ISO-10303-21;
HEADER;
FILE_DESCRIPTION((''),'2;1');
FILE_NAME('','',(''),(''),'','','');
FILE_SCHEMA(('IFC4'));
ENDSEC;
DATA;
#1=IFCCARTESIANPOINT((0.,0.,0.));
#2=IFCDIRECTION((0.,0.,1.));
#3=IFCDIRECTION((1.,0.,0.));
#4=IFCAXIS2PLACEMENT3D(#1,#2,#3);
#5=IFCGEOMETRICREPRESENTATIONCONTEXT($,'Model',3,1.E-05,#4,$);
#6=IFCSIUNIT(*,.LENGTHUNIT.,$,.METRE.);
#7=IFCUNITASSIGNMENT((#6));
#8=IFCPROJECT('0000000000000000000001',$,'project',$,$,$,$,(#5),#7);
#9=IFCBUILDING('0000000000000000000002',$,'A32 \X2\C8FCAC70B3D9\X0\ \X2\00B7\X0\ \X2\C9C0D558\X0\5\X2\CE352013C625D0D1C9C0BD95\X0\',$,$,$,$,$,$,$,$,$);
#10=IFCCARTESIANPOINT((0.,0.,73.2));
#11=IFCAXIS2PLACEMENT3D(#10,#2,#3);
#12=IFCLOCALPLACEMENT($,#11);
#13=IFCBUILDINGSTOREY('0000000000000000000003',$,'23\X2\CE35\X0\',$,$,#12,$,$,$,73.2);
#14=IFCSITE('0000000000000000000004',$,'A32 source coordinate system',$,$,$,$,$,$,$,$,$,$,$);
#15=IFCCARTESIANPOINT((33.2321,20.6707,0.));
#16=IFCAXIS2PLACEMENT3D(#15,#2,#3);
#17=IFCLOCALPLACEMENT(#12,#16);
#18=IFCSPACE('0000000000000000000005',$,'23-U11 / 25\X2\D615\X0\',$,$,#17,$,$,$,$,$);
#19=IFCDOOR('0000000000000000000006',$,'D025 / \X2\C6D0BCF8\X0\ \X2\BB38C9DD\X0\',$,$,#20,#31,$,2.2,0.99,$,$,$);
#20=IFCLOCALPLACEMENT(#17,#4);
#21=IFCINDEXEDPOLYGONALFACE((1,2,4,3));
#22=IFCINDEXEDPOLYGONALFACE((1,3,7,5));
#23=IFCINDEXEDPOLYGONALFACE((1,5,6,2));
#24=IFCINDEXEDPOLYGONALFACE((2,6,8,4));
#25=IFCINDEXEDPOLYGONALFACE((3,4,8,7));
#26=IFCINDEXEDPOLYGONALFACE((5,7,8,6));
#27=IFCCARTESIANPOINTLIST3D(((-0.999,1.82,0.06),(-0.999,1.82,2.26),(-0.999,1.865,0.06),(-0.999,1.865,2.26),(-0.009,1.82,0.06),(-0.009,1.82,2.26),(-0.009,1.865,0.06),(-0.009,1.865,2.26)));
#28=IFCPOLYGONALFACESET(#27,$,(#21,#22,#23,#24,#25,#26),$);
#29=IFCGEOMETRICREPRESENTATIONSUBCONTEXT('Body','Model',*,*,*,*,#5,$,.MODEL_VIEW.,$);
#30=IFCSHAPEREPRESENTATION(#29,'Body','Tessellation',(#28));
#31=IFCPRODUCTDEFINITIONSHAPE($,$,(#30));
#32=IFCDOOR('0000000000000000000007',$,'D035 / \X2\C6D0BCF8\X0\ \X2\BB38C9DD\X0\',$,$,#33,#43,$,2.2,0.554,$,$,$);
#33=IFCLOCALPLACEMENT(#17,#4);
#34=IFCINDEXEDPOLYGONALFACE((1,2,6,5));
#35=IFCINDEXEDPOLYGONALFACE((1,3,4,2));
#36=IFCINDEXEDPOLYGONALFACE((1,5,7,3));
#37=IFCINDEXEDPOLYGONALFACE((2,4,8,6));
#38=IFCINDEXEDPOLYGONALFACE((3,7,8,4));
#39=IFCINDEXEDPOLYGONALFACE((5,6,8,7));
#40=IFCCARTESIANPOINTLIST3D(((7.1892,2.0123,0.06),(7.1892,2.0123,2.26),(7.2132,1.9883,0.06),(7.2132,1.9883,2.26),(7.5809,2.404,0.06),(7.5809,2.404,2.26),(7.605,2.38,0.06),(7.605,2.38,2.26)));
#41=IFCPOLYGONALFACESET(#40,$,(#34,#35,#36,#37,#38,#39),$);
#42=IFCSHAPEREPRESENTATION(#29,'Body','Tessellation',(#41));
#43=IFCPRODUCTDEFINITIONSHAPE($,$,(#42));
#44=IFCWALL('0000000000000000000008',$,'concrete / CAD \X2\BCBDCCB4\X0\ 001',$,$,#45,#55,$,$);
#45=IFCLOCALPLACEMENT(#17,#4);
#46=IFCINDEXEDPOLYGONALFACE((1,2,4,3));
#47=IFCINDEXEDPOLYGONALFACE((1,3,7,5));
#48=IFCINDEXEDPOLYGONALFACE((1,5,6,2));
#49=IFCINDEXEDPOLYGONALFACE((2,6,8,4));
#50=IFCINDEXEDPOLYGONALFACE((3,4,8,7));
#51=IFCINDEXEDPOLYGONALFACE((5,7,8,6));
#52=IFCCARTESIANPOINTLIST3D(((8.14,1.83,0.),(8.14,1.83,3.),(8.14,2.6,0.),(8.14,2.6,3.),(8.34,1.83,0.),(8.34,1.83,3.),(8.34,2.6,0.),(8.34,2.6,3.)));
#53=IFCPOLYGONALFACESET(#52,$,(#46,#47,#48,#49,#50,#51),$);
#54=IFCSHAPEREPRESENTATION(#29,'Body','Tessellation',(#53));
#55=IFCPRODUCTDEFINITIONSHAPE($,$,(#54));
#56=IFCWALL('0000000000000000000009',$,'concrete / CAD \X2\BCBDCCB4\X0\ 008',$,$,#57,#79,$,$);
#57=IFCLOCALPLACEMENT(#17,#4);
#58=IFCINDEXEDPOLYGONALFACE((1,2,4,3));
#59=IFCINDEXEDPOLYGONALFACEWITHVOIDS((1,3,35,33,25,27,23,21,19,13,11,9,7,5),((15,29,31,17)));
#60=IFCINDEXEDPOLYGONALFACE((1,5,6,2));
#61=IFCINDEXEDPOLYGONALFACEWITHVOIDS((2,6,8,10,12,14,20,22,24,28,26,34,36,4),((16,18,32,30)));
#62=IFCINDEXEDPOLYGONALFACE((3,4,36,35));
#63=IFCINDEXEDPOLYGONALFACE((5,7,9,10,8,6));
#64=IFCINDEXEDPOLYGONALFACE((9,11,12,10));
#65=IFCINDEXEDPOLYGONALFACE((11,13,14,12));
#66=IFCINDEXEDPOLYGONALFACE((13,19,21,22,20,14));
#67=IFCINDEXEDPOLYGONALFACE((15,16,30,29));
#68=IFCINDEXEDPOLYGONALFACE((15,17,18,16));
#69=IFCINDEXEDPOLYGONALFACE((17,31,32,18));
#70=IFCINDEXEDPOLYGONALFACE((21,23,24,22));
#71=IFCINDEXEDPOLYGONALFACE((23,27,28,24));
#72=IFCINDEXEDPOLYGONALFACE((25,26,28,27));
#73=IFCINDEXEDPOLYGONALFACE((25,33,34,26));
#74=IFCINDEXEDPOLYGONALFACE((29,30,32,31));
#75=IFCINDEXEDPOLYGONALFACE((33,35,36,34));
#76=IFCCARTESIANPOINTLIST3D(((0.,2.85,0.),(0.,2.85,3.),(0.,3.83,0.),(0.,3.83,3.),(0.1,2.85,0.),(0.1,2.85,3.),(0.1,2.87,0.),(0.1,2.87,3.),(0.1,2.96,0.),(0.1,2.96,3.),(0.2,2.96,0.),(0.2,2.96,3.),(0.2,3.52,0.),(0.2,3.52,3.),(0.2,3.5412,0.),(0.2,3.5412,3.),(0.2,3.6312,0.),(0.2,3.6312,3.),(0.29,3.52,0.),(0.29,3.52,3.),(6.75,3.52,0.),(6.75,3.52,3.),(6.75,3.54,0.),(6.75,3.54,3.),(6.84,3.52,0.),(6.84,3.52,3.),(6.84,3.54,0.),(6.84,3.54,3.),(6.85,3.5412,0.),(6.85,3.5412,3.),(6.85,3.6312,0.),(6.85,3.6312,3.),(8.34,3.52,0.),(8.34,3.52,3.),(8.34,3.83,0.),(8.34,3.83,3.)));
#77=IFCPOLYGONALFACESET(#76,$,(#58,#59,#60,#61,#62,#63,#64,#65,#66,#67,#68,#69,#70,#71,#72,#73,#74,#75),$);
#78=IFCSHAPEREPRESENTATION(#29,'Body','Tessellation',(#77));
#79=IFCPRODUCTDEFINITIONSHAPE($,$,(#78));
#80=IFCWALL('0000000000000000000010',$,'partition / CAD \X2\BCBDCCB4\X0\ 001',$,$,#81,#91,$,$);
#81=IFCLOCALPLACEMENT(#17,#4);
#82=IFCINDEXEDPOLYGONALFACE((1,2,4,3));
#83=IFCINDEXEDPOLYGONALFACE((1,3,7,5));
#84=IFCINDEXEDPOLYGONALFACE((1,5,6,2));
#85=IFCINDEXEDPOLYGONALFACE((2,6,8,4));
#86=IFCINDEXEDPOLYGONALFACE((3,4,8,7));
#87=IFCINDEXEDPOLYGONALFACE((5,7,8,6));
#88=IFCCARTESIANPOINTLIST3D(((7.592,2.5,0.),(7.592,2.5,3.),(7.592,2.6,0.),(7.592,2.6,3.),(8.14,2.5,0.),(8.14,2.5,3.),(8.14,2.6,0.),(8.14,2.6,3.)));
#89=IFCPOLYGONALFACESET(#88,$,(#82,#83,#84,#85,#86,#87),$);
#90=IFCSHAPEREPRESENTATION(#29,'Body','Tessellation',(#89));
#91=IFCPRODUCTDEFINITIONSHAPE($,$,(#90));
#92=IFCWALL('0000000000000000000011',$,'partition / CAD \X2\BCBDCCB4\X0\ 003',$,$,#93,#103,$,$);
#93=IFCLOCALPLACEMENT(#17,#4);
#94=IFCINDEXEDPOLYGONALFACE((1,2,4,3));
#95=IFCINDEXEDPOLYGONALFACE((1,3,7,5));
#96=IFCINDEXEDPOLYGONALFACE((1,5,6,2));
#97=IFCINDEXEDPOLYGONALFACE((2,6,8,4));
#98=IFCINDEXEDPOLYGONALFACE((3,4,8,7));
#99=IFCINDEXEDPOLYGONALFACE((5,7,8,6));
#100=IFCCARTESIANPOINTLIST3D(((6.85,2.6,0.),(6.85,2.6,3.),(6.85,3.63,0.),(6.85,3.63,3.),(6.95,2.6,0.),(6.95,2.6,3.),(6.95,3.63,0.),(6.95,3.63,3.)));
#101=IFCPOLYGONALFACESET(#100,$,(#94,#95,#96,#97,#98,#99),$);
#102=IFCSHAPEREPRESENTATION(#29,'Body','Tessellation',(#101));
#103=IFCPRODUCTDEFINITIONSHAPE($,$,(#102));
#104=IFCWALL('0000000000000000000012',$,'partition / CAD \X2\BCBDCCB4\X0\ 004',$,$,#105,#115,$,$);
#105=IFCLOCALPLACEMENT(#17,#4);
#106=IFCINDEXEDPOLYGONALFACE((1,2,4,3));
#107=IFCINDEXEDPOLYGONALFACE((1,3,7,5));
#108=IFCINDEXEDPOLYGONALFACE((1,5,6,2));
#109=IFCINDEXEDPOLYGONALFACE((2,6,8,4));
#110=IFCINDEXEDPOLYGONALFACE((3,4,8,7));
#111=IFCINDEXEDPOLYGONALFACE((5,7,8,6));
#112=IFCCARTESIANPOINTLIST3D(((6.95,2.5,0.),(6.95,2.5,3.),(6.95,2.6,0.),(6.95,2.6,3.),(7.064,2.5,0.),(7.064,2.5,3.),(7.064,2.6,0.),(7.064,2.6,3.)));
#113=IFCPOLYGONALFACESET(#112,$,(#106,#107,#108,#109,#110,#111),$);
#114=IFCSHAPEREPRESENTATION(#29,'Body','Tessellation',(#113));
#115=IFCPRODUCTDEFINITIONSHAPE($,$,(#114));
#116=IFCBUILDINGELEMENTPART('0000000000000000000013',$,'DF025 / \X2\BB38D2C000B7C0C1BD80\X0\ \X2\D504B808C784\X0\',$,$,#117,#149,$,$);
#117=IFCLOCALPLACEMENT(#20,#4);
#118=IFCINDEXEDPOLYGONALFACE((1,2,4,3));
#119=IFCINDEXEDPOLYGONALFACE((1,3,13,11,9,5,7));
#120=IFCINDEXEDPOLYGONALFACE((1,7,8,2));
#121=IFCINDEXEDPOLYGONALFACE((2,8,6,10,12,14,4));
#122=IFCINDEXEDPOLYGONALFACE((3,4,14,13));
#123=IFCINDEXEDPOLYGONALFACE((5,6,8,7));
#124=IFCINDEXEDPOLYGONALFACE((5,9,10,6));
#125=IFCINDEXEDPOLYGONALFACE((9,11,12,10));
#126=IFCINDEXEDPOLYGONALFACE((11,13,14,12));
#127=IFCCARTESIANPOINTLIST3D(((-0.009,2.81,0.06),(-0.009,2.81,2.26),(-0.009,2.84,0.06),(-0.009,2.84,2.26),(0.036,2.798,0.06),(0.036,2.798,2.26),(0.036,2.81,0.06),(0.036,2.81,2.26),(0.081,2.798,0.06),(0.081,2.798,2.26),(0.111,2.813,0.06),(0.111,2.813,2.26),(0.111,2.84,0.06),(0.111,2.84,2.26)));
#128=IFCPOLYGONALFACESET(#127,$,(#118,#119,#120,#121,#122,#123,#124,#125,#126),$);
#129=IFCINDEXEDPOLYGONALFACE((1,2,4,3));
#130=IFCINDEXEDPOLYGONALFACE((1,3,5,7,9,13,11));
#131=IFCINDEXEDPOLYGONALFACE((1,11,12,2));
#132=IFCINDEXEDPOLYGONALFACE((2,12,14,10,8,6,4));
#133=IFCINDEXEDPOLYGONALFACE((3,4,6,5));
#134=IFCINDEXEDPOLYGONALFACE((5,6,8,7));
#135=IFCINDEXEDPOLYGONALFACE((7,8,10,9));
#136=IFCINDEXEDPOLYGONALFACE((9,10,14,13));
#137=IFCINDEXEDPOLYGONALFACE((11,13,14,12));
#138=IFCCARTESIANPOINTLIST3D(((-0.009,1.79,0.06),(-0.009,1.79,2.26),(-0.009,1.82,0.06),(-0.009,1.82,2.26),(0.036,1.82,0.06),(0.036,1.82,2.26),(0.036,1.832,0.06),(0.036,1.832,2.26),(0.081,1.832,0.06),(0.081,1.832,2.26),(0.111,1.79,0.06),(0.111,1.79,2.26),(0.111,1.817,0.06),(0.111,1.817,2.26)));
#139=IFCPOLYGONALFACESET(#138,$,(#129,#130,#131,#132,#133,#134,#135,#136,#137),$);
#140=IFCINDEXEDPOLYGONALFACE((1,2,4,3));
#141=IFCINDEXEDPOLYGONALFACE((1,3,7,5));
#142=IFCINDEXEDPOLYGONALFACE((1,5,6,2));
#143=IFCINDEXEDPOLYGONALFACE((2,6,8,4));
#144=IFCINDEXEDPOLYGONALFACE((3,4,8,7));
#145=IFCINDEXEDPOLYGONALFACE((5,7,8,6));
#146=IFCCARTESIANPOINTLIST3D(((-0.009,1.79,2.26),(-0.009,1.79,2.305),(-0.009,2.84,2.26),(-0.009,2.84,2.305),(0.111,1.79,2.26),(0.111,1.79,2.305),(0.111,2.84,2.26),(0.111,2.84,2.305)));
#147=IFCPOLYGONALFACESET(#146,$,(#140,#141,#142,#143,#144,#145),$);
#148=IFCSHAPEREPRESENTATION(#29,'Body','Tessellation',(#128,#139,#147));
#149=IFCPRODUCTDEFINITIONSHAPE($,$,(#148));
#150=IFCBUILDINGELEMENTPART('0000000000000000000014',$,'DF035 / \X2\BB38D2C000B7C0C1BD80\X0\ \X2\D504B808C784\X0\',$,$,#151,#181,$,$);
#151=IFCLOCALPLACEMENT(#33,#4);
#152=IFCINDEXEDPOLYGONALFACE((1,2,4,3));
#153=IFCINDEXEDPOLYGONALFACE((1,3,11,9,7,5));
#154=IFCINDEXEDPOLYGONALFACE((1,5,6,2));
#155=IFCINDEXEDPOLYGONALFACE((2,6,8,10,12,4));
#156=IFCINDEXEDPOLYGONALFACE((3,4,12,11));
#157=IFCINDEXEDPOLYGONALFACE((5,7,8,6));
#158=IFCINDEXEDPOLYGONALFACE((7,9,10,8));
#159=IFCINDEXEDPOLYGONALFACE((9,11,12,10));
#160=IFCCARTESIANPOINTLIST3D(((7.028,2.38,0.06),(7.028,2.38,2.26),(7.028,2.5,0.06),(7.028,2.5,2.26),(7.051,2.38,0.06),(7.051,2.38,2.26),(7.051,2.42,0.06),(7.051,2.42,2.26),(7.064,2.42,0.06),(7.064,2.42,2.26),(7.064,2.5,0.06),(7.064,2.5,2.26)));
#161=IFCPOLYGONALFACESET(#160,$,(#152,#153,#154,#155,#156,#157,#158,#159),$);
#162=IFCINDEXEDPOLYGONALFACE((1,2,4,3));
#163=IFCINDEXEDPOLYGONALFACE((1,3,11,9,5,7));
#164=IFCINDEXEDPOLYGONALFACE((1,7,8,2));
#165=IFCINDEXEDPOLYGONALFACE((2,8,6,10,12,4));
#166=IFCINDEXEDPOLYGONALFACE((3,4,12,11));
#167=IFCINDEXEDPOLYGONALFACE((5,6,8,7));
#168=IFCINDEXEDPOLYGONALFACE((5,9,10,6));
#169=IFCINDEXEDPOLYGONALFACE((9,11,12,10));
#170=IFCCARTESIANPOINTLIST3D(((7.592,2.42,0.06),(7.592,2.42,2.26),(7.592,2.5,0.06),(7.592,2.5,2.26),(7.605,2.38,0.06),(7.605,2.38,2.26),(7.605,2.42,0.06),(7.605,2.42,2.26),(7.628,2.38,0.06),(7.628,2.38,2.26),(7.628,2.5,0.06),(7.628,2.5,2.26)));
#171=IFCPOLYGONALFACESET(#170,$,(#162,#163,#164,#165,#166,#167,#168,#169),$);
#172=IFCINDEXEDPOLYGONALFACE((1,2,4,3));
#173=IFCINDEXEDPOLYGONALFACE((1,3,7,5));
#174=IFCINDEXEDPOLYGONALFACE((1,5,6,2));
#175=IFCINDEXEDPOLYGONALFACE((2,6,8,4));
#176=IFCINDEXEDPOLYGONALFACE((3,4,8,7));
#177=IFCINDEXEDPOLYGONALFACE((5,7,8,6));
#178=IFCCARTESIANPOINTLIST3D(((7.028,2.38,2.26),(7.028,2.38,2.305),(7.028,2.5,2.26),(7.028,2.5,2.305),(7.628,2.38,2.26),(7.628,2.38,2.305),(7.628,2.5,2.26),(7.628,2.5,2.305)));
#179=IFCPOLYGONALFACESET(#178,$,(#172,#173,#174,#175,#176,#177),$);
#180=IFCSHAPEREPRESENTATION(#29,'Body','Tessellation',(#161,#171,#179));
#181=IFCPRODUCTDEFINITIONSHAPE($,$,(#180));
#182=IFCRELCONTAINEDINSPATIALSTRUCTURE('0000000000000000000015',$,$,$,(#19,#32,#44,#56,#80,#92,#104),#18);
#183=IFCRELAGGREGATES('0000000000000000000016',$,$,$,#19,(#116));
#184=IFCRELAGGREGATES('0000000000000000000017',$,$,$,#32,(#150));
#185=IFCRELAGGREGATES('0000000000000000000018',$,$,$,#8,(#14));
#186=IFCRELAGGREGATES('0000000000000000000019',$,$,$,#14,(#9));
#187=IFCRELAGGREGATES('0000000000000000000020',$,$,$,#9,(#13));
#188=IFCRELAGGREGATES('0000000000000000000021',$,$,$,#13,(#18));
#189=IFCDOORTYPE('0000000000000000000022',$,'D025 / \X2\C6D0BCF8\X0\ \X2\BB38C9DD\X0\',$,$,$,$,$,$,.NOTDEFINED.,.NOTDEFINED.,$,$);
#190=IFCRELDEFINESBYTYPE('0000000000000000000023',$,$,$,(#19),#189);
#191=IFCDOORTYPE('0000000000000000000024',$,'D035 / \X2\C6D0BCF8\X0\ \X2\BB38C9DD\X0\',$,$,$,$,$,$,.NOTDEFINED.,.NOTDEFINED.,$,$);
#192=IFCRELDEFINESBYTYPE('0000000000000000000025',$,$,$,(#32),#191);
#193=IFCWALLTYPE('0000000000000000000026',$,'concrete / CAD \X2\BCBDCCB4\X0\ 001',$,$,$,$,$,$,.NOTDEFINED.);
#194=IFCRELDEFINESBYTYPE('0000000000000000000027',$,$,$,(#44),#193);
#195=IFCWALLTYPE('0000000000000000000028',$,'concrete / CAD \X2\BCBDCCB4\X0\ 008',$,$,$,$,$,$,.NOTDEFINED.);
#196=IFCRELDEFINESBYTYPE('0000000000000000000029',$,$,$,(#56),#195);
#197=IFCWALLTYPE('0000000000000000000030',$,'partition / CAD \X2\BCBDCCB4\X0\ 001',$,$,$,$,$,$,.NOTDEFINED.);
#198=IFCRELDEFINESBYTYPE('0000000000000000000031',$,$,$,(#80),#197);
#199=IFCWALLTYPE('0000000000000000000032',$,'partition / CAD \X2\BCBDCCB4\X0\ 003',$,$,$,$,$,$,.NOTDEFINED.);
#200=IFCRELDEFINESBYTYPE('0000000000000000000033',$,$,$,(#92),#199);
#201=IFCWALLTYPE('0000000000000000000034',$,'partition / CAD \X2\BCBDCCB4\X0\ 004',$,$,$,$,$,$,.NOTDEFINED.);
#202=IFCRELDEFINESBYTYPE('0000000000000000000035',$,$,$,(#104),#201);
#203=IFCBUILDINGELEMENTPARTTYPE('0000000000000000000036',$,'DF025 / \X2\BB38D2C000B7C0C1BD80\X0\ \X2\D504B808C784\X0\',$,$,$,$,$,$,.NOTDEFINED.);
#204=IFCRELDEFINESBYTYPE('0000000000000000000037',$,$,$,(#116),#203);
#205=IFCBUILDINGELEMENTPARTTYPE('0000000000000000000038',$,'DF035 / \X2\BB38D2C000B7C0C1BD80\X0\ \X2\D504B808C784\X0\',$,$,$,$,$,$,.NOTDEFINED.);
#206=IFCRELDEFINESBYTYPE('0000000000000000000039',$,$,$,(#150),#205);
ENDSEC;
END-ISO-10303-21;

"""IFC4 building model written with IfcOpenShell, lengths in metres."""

from ifc_helpers import new_model, si_unit, frame, origin, origin_with_axes, place, context, subcontext, project, spatial, polyline, outline, extrude, source, transform, mapped, type_object, type_shapes, element, aggregate, save


model = new_model("IFC4")

# Units and contexts
model_context = context("Model", 3, precision=1e-05, world=origin_with_axes())
body_context = subcontext(model_context, "Body", "Model", "MODEL_VIEW")
ifc_project = project(units=[si_unit("LENGTHUNIT", "METRE")], contexts=[model_context])

# Site, building, storey, space
storey_placement = place(None, frame((0.0, 0.0, 73.2), z_axis=(0.0, 0.0, 1.0), x_axis=(1.0, 0.0, 0.0)))
space_placement = place(storey_placement, frame((33.2321, 20.6707, 0.0), z_axis=(0.0, 0.0, 1.0), x_axis=(1.0, 0.0, 0.0)))
site = spatial("IfcSite", under=ifc_project, Name="A32 source coordinate system")
building = spatial("IfcBuilding", under=site, Name="A32 주거동 · 지하5층–옥탑지붕")
storey = spatial("IfcBuildingStorey", under=building, at=storey_placement, Name="23층", Elevation=73.2)
space = spatial("IfcSpace", under=storey, at=space_placement, Name="23-U11 / 25형")

# Doors
door_type_1 = type_object("IfcDoorType", Name="D025 / 원본 문짝", OperationType="NOTDEFINED", PredefinedType="NOTDEFINED")
shared_shape_1 = source(origin(), body_context, "Body", "SweptSolid", [
    extrude(outline(polyline([(-0.009, 1.82), (-0.999, 1.82), (-0.999, 1.865), (-0.009, 1.865), (-0.009, 1.82)])), frame((0.0, 0.0, 0.06)), (0.0, 0.0, 1.0), 2.2),
])
type_shapes(door_type_1, [shared_shape_1])
door_1_placement = place(space_placement, origin_with_axes())
door_1 = element("IfcDoor", 1, at=door_1_placement, inside=space, type_object=door_type_1, Name="D025 / 원본 문짝", OverallHeight=2.2, OverallWidth=0.99, context=body_context, shape_type="MappedRepresentation", body=[
    mapped(shared_shape_1, transform((0.0, 0.0, 0.0), scale=1.0)),
])
door_type_2 = type_object("IfcDoorType", Name="D035 / 원본 문짝", OperationType="NOTDEFINED", PredefinedType="NOTDEFINED")
shared_shape_2 = source(origin(), body_context, "Body", "SweptSolid", [
    extrude(outline(polyline([(7.605, 2.38), (7.2132, 1.9883), (7.1892, 2.0123), (7.5809, 2.404), (7.605, 2.38)])), frame((0.0, 0.0, 0.06)), (0.0, 0.0, 1.0), 2.2),
])
type_shapes(door_type_2, [shared_shape_2])
door_2_placement = place(space_placement, origin_with_axes())
door_2 = element("IfcDoor", 2, at=door_2_placement, inside=space, type_object=door_type_2, Name="D035 / 원본 문짝", OverallHeight=2.2, OverallWidth=0.554, context=body_context, shape_type="MappedRepresentation", body=[
    mapped(shared_shape_2, transform((0.0, 0.0, 0.0), scale=1.0)),
])

# Walls
wall_type_1 = type_object("IfcWallType", Name="concrete / CAD 벽체 001", PredefinedType="NOTDEFINED")
shared_shape_3 = source(origin(), body_context, "Body", "SweptSolid", [
    extrude(outline(polyline([(8.34, 1.83), (8.14, 1.83), (8.14, 2.6), (8.34, 2.6), (8.34, 1.83)])), origin(), (0.0, 0.0, 1.0), 3.0),
])
type_shapes(wall_type_1, [shared_shape_3])
wall_1_placement = place(space_placement, origin_with_axes())
element("IfcWall", 3, at=wall_1_placement, inside=space, type_object=wall_type_1, Name="concrete / CAD 벽체 001", context=body_context, shape_type="MappedRepresentation", body=[
    mapped(shared_shape_3, transform((0.0, 0.0, 0.0), scale=1.0)),
])
wall_type_2 = type_object("IfcWallType", Name="concrete / CAD 벽체 008", PredefinedType="NOTDEFINED")
shared_shape_4 = source(origin(), body_context, "Body", "SweptSolid", [
    extrude(outline(polyline([(0.0, 3.83), (8.34, 3.83), (8.34, 3.52), (6.84, 3.52), (6.84, 3.54), (6.75, 3.54), (6.75, 3.52), (0.29, 3.52), (0.2, 3.52), (0.2, 2.96), (0.1, 2.96), (0.1, 2.87), (0.1, 2.85), (0.0, 2.85), (0.0, 3.83)]), holes=[polyline([(6.85, 3.5412), (6.85, 3.6312), (0.2, 3.6312), (0.2, 3.5412), (6.85, 3.5412)])]), origin(), (0.0, 0.0, 1.0), 3.0),
])
type_shapes(wall_type_2, [shared_shape_4])
wall_2_placement = place(space_placement, origin_with_axes())
element("IfcWall", 4, at=wall_2_placement, inside=space, type_object=wall_type_2, Name="concrete / CAD 벽체 008", context=body_context, shape_type="MappedRepresentation", body=[
    mapped(shared_shape_4, transform((0.0, 0.0, 0.0), scale=1.0)),
])
wall_type_3 = type_object("IfcWallType", Name="partition / CAD 벽체 001", PredefinedType="NOTDEFINED")
shared_shape_5 = source(origin(), body_context, "Body", "SweptSolid", [
    extrude(outline(polyline([(8.14, 2.6), (8.14, 2.5), (7.592, 2.5), (7.592, 2.6), (8.14, 2.6)])), origin(), (0.0, 0.0, 1.0), 3.0),
])
type_shapes(wall_type_3, [shared_shape_5])
wall_3_placement = place(space_placement, origin_with_axes())
element("IfcWall", 5, at=wall_3_placement, inside=space, type_object=wall_type_3, Name="partition / CAD 벽체 001", context=body_context, shape_type="MappedRepresentation", body=[
    mapped(shared_shape_5, transform((0.0, 0.0, 0.0), scale=1.0)),
])
wall_type_4 = type_object("IfcWallType", Name="partition / CAD 벽체 003", PredefinedType="NOTDEFINED")
shared_shape_6 = source(origin(), body_context, "Body", "SweptSolid", [
    extrude(outline(polyline([(6.85, 2.6), (6.85, 3.63), (6.95, 3.63), (6.95, 2.6), (6.85, 2.6)])), origin(), (0.0, 0.0, 1.0), 3.0),
])
type_shapes(wall_type_4, [shared_shape_6])
wall_4_placement = place(space_placement, origin_with_axes())
element("IfcWall", 6, at=wall_4_placement, inside=space, type_object=wall_type_4, Name="partition / CAD 벽체 003", context=body_context, shape_type="MappedRepresentation", body=[
    mapped(shared_shape_6, transform((0.0, 0.0, 0.0), scale=1.0)),
])
wall_type_5 = type_object("IfcWallType", Name="partition / CAD 벽체 004", PredefinedType="NOTDEFINED")
shared_shape_7 = source(origin(), body_context, "Body", "SweptSolid", [
    extrude(outline(polyline([(6.95, 2.5), (6.95, 2.6), (7.064, 2.6), (7.064, 2.5), (6.95, 2.5)])), origin(), (0.0, 0.0, 1.0), 3.0),
])
type_shapes(wall_type_5, [shared_shape_7])
wall_5_placement = place(space_placement, origin_with_axes())
element("IfcWall", 7, at=wall_5_placement, inside=space, type_object=wall_type_5, Name="partition / CAD 벽체 004", context=body_context, shape_type="MappedRepresentation", body=[
    mapped(shared_shape_7, transform((0.0, 0.0, 0.0), scale=1.0)),
])

# Building element parts
building_element_part_type_1 = type_object("IfcBuildingElementPartType", Name="DF025 / 문틀·상부 프레임", PredefinedType="NOTDEFINED")
shared_shape_8 = source(origin(), body_context, "Body", "SweptSolid", [
    extrude(outline(polyline([(0.111, 2.84), (0.111, 2.813), (0.081, 2.798), (0.036, 2.798), (0.036, 2.81), (-0.009, 2.81), (-0.009, 2.84), (0.111, 2.84)])), frame((0.0, 0.0, 0.06)), (0.0, 0.0, 1.0), 2.2),
    extrude(outline(polyline([(-0.009, 1.82), (0.036, 1.82), (0.036, 1.832), (0.081, 1.832), (0.111, 1.817), (0.111, 1.79), (-0.009, 1.79), (-0.009, 1.82)])), frame((0.0, 0.0, 0.06)), (0.0, 0.0, 1.0), 2.2),
    extrude(outline(polyline([(-0.009, 1.79), (-0.009, 2.84), (0.111, 2.84), (0.111, 1.79), (-0.009, 1.79)])), frame((0.0, 0.0, 2.26)), (0.0, 0.0, 1.0), 0.045),
])
type_shapes(building_element_part_type_1, [shared_shape_8])
building_element_part_1_placement = place(door_1_placement, origin_with_axes())
building_element_part_1 = element("IfcBuildingElementPart", 8, at=building_element_part_1_placement, type_object=building_element_part_type_1, Name="DF025 / 문틀·상부 프레임", context=body_context, shape_type="MappedRepresentation", body=[
    mapped(shared_shape_8, transform((0.0, 0.0, 0.0), scale=1.0)),
])
aggregate(door_1, [building_element_part_1])
building_element_part_type_2 = type_object("IfcBuildingElementPartType", Name="DF035 / 문틀·상부 프레임", PredefinedType="NOTDEFINED")
shared_shape_9 = source(origin(), body_context, "Body", "SweptSolid", [
    extrude(outline(polyline([(7.064, 2.5), (7.064, 2.42), (7.051, 2.42), (7.051, 2.38), (7.028, 2.38), (7.028, 2.5), (7.064, 2.5)])), frame((0.0, 0.0, 0.06)), (0.0, 0.0, 1.0), 2.2),
    extrude(outline(polyline([(7.628, 2.38), (7.605, 2.38), (7.605, 2.42), (7.592, 2.42), (7.592, 2.5), (7.628, 2.5), (7.628, 2.38)])), frame((0.0, 0.0, 0.06)), (0.0, 0.0, 1.0), 2.2),
    extrude(outline(polyline([(7.028, 2.38), (7.028, 2.5), (7.628, 2.5), (7.628, 2.38), (7.028, 2.38)])), frame((0.0, 0.0, 2.26)), (0.0, 0.0, 1.0), 0.045),
])
type_shapes(building_element_part_type_2, [shared_shape_9])
building_element_part_2_placement = place(door_2_placement, origin_with_axes())
building_element_part_2 = element("IfcBuildingElementPart", 9, at=building_element_part_2_placement, type_object=building_element_part_type_2, Name="DF035 / 문틀·상부 프레임", context=body_context, shape_type="MappedRepresentation", body=[
    mapped(shared_shape_9, transform((0.0, 0.0, 0.0), scale=1.0)),
])
aggregate(door_2, [building_element_part_2])

save(model, "model.ifc")
